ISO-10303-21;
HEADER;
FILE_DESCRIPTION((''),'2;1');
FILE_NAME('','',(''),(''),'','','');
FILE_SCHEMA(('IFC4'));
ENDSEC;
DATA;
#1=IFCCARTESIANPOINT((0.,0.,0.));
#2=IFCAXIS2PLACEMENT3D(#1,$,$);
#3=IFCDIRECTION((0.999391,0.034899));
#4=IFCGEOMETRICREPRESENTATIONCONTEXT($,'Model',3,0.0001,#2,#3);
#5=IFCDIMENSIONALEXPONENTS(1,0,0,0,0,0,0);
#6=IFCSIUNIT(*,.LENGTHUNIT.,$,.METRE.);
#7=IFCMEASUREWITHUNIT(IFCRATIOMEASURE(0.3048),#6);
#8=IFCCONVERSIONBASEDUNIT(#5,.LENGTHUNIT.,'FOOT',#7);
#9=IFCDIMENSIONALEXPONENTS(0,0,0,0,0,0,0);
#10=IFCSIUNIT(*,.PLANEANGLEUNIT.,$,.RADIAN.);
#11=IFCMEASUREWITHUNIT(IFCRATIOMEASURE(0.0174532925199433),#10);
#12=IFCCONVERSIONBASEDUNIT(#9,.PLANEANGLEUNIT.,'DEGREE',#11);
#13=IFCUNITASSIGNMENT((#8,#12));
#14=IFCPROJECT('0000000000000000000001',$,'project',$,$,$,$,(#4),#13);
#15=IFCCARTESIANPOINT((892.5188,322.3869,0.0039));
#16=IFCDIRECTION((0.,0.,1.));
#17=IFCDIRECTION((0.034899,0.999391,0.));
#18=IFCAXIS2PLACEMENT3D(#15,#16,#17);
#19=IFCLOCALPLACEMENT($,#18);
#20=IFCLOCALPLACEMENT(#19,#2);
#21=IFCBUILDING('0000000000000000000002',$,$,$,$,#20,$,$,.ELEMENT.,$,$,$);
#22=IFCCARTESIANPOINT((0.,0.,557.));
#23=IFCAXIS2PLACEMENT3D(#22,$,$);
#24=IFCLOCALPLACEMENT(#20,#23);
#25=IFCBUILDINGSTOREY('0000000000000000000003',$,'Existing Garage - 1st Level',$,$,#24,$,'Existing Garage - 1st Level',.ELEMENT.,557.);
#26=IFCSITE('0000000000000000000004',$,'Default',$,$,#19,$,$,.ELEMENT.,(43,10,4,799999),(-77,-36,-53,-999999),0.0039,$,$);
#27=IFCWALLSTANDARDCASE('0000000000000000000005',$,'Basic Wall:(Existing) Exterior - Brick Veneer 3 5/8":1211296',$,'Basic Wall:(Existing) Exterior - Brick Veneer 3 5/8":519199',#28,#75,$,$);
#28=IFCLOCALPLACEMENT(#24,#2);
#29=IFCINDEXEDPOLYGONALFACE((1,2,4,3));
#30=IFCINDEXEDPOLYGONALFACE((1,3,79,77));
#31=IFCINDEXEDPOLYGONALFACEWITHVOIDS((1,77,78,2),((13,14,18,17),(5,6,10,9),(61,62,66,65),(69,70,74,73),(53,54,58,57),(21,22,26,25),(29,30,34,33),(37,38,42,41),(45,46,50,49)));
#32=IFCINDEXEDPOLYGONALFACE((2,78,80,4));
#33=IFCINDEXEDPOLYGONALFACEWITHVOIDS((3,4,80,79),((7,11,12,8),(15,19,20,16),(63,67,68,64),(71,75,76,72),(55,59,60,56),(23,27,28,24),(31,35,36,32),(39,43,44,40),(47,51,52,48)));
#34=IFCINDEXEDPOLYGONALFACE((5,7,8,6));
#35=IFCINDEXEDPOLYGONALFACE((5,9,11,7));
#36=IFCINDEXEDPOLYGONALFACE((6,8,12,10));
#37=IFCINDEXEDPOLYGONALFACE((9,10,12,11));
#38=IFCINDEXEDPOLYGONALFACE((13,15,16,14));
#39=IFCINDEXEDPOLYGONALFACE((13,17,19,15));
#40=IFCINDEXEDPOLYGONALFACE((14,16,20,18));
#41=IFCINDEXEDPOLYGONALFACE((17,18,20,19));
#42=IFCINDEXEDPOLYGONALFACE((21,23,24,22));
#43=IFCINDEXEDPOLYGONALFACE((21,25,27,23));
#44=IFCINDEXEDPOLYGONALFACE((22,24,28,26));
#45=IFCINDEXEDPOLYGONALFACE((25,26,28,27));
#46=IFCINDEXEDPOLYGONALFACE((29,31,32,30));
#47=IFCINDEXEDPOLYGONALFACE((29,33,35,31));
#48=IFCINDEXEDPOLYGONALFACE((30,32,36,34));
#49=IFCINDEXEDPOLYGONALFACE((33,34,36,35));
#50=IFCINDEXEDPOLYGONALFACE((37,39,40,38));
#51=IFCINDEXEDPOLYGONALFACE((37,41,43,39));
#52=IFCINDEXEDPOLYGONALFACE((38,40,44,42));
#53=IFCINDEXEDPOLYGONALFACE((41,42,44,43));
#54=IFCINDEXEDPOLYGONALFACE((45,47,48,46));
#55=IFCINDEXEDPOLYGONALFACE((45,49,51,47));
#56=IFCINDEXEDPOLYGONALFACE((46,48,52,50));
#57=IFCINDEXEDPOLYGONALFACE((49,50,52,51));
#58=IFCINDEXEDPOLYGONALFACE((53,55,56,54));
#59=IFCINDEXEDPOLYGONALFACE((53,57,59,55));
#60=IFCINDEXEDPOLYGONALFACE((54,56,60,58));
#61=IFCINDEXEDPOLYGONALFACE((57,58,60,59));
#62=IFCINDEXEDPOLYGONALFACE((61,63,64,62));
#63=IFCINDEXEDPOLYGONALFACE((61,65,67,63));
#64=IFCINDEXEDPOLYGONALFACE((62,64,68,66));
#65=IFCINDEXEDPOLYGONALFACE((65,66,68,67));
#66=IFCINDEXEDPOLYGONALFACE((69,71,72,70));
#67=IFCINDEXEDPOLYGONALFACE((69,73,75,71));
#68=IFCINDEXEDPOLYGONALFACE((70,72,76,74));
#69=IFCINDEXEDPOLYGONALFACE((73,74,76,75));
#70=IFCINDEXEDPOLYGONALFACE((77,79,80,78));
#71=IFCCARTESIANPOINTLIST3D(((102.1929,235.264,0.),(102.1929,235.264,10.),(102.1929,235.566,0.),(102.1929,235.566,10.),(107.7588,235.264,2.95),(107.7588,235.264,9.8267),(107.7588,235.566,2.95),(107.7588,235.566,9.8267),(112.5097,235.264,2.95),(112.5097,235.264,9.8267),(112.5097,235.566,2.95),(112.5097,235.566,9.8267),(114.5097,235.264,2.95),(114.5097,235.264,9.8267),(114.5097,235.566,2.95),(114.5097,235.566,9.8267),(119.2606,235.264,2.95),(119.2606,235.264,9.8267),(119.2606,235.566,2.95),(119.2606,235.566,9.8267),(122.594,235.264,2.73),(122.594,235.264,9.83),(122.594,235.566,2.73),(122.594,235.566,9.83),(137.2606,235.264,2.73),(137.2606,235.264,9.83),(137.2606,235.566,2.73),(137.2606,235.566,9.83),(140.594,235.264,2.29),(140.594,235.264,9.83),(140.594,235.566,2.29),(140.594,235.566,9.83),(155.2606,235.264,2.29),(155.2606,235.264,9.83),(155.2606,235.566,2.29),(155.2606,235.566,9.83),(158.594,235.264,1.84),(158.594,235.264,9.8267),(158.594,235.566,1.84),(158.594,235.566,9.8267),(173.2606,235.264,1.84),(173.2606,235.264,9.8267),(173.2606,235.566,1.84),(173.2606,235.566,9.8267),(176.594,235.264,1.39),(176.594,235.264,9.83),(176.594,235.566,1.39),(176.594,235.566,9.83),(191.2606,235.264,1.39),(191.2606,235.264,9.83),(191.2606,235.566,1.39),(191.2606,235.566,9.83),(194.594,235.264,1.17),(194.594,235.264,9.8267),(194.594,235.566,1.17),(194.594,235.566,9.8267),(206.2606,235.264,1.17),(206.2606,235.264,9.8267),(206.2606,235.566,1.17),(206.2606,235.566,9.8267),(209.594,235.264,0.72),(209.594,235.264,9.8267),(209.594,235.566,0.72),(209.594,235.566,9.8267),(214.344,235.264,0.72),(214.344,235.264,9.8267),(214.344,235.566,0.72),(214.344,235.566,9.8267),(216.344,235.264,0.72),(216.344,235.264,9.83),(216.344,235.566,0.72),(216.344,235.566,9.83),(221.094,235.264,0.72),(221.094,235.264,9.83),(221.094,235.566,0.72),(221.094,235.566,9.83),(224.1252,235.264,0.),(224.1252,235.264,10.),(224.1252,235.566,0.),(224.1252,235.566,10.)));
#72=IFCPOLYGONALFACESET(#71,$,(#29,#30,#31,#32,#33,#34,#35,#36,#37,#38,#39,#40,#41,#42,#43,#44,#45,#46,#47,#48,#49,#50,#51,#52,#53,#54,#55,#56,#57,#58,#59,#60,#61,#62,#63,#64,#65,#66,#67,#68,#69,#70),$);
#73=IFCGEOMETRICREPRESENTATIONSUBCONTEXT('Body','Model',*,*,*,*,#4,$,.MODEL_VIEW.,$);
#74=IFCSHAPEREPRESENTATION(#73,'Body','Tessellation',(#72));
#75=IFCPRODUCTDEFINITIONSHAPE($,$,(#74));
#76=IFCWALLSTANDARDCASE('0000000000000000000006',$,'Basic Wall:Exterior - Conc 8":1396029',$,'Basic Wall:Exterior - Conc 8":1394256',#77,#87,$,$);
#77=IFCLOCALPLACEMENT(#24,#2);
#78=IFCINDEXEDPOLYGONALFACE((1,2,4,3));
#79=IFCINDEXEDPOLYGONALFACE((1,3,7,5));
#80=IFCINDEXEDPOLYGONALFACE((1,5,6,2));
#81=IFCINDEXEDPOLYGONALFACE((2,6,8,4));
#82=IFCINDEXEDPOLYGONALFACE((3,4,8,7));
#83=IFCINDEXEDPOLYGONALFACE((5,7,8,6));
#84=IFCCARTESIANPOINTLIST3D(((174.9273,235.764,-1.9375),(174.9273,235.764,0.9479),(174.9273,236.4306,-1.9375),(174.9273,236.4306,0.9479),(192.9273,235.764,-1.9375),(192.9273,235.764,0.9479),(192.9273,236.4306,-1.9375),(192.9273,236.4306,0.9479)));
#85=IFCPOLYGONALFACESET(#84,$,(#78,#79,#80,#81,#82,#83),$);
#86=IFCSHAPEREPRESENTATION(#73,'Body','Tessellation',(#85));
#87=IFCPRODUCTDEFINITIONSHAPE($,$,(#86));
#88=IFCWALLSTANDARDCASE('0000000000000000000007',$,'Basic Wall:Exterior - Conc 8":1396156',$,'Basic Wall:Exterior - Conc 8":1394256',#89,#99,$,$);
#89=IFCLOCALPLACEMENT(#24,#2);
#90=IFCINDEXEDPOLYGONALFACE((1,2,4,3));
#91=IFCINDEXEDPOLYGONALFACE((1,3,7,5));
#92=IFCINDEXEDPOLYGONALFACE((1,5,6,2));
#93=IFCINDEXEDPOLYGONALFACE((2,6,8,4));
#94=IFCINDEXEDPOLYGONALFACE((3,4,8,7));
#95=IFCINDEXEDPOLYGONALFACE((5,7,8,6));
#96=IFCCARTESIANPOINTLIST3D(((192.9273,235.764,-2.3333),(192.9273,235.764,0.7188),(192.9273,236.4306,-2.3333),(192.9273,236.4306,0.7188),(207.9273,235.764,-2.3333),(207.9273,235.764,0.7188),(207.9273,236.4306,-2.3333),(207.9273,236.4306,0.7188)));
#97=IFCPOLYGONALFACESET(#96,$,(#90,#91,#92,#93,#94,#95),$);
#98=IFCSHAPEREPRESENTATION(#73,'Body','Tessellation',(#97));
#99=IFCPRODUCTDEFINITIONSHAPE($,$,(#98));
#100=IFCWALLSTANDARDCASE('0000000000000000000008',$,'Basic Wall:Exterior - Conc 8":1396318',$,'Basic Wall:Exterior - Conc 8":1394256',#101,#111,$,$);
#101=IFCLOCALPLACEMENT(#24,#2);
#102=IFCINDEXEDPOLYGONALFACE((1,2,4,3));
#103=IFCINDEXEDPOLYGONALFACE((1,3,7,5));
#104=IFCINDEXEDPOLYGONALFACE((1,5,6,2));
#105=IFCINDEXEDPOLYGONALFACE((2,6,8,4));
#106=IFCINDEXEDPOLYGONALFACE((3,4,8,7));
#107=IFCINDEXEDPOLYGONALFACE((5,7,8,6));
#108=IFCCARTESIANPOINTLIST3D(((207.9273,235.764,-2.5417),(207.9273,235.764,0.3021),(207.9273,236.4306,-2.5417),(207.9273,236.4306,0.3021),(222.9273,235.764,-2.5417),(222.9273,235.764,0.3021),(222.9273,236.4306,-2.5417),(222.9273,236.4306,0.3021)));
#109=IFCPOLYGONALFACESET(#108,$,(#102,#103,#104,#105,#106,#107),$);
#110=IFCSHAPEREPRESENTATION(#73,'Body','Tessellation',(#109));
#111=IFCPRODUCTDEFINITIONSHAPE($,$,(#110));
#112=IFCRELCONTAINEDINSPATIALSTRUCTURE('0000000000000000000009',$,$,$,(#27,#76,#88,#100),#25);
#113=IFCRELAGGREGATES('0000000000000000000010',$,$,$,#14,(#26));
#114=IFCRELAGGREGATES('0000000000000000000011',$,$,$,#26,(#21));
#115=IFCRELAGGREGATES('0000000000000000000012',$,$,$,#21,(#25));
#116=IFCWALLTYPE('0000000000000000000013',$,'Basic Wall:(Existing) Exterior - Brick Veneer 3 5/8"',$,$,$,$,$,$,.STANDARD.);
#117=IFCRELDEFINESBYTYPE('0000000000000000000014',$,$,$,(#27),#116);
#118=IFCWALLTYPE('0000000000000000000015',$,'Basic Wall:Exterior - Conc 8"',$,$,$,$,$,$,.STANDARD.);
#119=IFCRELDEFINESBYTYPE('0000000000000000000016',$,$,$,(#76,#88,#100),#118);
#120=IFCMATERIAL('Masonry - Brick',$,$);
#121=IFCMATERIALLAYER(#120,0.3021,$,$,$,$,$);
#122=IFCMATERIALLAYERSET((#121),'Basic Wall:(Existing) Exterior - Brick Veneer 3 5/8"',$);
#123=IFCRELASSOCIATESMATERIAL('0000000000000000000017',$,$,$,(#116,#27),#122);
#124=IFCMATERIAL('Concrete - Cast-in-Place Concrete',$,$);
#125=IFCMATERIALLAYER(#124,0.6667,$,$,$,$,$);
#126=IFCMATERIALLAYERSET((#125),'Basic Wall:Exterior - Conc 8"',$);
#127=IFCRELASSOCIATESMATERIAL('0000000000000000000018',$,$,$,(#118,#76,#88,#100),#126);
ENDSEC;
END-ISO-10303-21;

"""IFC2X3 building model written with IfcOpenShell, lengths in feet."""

from ifc_helpers import new_model, entity, si_unit, converted_unit, direction, frame, frame_2d, origin, origin_2d_with_axis, place, context, subcontext, project, spatial, rectangle, extrude, material, layer, layer_set, layer_usage, type_object, element, save


model = new_model("IFC2X3")

# Units and contexts
model_context = context("Model", 3, precision=0.0001, world=origin(), true_north=direction((0.999391, 0.034899)))
body_context = subcontext(model_context, "Body", "Model", "MODEL_VIEW")
ifc_project = project(units=[converted_unit("LENGTHUNIT", "FOOT", entity("IfcRatioMeasure", 0.3048), si_unit("LENGTHUNIT", "METRE"), dimensions=[1, 0, 0, 0, 0, 0, 0]), converted_unit("PLANEANGLEUNIT", "DEGREE", entity("IfcRatioMeasure", 0.0174532925199433), si_unit("PLANEANGLEUNIT", "RADIAN"), dimensions=[0, 0, 0, 0, 0, 0, 0])], contexts=[model_context])

# Site, building, storey
site_placement = place(None, frame((892.5188, 322.3869, 0.0039), z_axis=(0.0, 0.0, 1.0), x_axis=(0.034899, 0.999391, 0.0)))
site = spatial("IfcSite", under=ifc_project, at=site_placement, Name="Default", CompositionType="ELEMENT", RefLatitude=(43, 10, 4, 799999), RefLongitude=(-77, -36, -53, -999999), RefElevation=0.0039)
building_placement = place(site_placement, origin())
building = spatial("IfcBuilding", under=site, at=building_placement, CompositionType="ELEMENT")
storey_placement = place(building_placement, frame((0.0, 0.0, 557.0)))
storey = spatial("IfcBuildingStorey", under=building, at=storey_placement, Name="Existing Garage - 1st Level", LongName="Existing Garage - 1st Level", CompositionType="ELEMENT", Elevation=557.0)

# Shared definitions
ifc_material_1 = material(Name="Concrete - Cast-in-Place Concrete")

# Wall, openings
ifc_material_2 = material(Name="Masonry - Brick")
ifc_layer_1 = layer(ifc_material_2, 0.3021)
ifc_layer_set_1 = layer_set([ifc_layer_1], Name="Basic Wall:(Existing) Exterior - Brick Veneer 3 5/8\"")
ifc_layer_usage_1 = layer_usage(ifc_layer_set_1, "AXIS2", "NEGATIVE", 0.151)
wall_type_1 = type_object("IfcWallType", Name="Basic Wall:(Existing) Exterior - Brick Veneer 3 5/8\"", PredefinedType="STANDARD", material=ifc_layer_set_1)
wall_1_placement = place(storey_placement, frame((224.1252, 235.415, 0.0), z_axis=(0.0, 0.0, 1.0), x_axis=(-1.0, 0.0, 0.0)))
wall_1 = element("IfcWallStandardCase", 1, at=wall_1_placement, inside=storey, type_object=wall_type_1, material=ifc_layer_usage_1, Name="Basic Wall:(Existing) Exterior - Brick Veneer 3 5/8\":1211296", ObjectType="Basic Wall:(Existing) Exterior - Brick Veneer 3 5/8\":519199", context=body_context, shape_type="SweptSolid", body=[
    extrude(rectangle(XDim=121.9323, YDim=0.3021, at=frame_2d((60.9661, 0.0), x_axis=(-1.0, 0.0))), origin(), (0.0, 0.0, 1.0), 10.0),
])
opening_1_placement = place(wall_1_placement, origin())
element("IfcOpeningElement", 2, at=opening_1_placement, cuts=wall_1, ObjectType="Opening", context=body_context, shape_type="SweptSolid", body=[
    extrude(rectangle(XDim=6.8767, YDim=4.7509, at=frame_2d((0.0, 0.0), x_axis=(1.0, 0.0))), frame((113.991, 0.151, 6.3883), z_axis=(0.0, -1.0, 0.0), x_axis=(0.0, 0.0, 1.0)), (0.0, 0.0, 1.0), 0.3021),
])
opening_2_placement = place(wall_1_placement, origin())
element("IfcOpeningElement", 3, at=opening_2_placement, cuts=wall_1, ObjectType="Opening", context=body_context, shape_type="SweptSolid", body=[
    extrude(rectangle(XDim=6.8767, YDim=4.7509, at=frame_2d((0.0, 0.0), x_axis=(1.0, 0.0))), frame((107.2401, 0.151, 6.3883), z_axis=(0.0, -1.0, 0.0), x_axis=(0.0, 0.0, 1.0)), (0.0, 0.0, 1.0), 0.3021),
])
opening_3_placement = place(wall_1_placement, origin())
element("IfcOpeningElement", 4, at=opening_3_placement, cuts=wall_1, ObjectType="Opening", context=body_context, shape_type="SweptSolid", body=[
    extrude(rectangle(XDim=7.1, YDim=14.6667, at=frame_2d((0.0, 0.0), x_axis=(1.0, 0.0))), frame((94.1979, 0.151, 6.28), z_axis=(0.0, -1.0, 0.0), x_axis=(0.0, 0.0, 1.0)), (0.0, 0.0, 1.0), 0.3021),
])
opening_4_placement = place(wall_1_placement, origin())
element("IfcOpeningElement", 5, at=opening_4_placement, cuts=wall_1, ObjectType="Opening", context=body_context, shape_type="SweptSolid", body=[
    extrude(rectangle(XDim=7.54, YDim=14.6667, at=frame_2d((0.0, 0.0), x_axis=(1.0, 0.0))), frame((76.1979, 0.151, 6.06), z_axis=(0.0, -1.0, 0.0), x_axis=(0.0, 0.0, 1.0)), (0.0, 0.0, 1.0), 0.3021),
])
opening_5_placement = place(wall_1_placement, origin())
element("IfcOpeningElement", 6, at=opening_5_placement, cuts=wall_1, ObjectType="Opening", context=body_context, shape_type="SweptSolid", body=[
    extrude(rectangle(XDim=7.9867, YDim=14.6667, at=frame_2d((0.0, 0.0), x_axis=(1.0, 0.0))), frame((58.1979, 0.151, 5.8333), z_axis=(0.0, -1.0, 0.0), x_axis=(0.0, 0.0, 1.0)), (0.0, 0.0, 1.0), 0.3021),
])
opening_6_placement = place(wall_1_placement, origin())
element("IfcOpeningElement", 7, at=opening_6_placement, cuts=wall_1, ObjectType="Opening", context=body_context, shape_type="SweptSolid", body=[
    extrude(rectangle(XDim=8.44, YDim=14.6667, at=origin_2d_with_axis()), frame((40.1979, 0.151, 5.61), z_axis=(0.0, -1.0, 0.0), x_axis=(0.0, 0.0, 1.0)), (0.0, 0.0, 1.0), 0.3021),
])
opening_7_placement = place(wall_1_placement, origin())
element("IfcOpeningElement", 8, at=opening_7_placement, cuts=wall_1, ObjectType="Opening", context=body_context, shape_type="SweptSolid", body=[
    extrude(rectangle(XDim=8.6567, YDim=11.6667, at=frame_2d((0.0, 0.0), x_axis=(1.0, 0.0))), frame((23.6979, 0.151, 5.4983), z_axis=(0.0, -1.0, 0.0), x_axis=(0.0, 0.0, 1.0)), (0.0, 0.0, 1.0), 0.3021),
])
opening_8_placement = place(wall_1_placement, origin())
element("IfcOpeningElement", 9, at=opening_8_placement, cuts=wall_1, ObjectType="Opening", context=body_context, shape_type="SweptSolid", body=[
    extrude(rectangle(XDim=9.1067, YDim=4.75, at=frame_2d((0.0, 0.0), x_axis=(1.0, 0.0))), frame((12.1563, 0.151, 5.2733), z_axis=(0.0, -1.0, 0.0), x_axis=(0.0, 0.0, 1.0)), (0.0, 0.0, 1.0), 0.3021),
])
opening_9_placement = place(wall_1_placement, origin())
element("IfcOpeningElement", 10, at=opening_9_placement, cuts=wall_1, ObjectType="Opening", context=body_context, shape_type="SweptSolid", body=[
    extrude(rectangle(XDim=9.11, YDim=4.75, at=frame_2d((0.0, 0.0), x_axis=(1.0, 0.0))), frame((5.4063, 0.151, 5.275), z_axis=(0.0, -1.0, 0.0), x_axis=(0.0, 0.0, 1.0)), (0.0, 0.0, 1.0), 0.3021),
])

# Walls
ifc_layer_2 = layer(ifc_material_1, 0.6667)
ifc_layer_set_2 = layer_set([ifc_layer_2], Name="Basic Wall:Exterior - Conc 8\"")
ifc_layer_usage_2 = layer_usage(ifc_layer_set_2, "AXIS2", "NEGATIVE", 0.3333)
wall_type_2 = type_object("IfcWallType", Name="Basic Wall:Exterior - Conc 8\"", PredefinedType="STANDARD", material=ifc_layer_set_2)
wall_2_placement = place(storey_placement, frame((192.9273, 236.0973, -1.9375), z_axis=(0.0, 0.0, 1.0), x_axis=(-1.0, 0.0, 0.0)))
element("IfcWallStandardCase", 11, at=wall_2_placement, inside=storey, type_object=wall_type_2, material=ifc_layer_usage_2, Name="Basic Wall:Exterior - Conc 8\":1396029", ObjectType="Basic Wall:Exterior - Conc 8\":1394256", context=body_context, shape_type="SweptSolid", body=[
    extrude(rectangle(XDim=18.0, YDim=0.6667, at=frame_2d((9.0, 0.0), x_axis=(-1.0, 0.0))), origin(), (0.0, 0.0, 1.0), 2.8854),
])
ifc_layer_usage_3 = layer_usage(ifc_layer_set_2, "AXIS2", "POSITIVE", -0.3333)
wall_3_placement = place(storey_placement, frame((192.9273, 236.0973, -2.3333)))
element("IfcWallStandardCase", 12, at=wall_3_placement, inside=storey, type_object=wall_type_2, material=ifc_layer_usage_3, Name="Basic Wall:Exterior - Conc 8\":1396156", ObjectType="Basic Wall:Exterior - Conc 8\":1394256", context=body_context, shape_type="SweptSolid", body=[
    extrude(rectangle(XDim=15.0, YDim=0.6667, at=frame_2d((7.5, 0.0), x_axis=(-1.0, 0.0))), origin(), (0.0, 0.0, 1.0), 3.0521),
])
ifc_layer_usage_4 = layer_usage(ifc_layer_set_2, "AXIS2", "NEGATIVE", 0.3333)
wall_4_placement = place(storey_placement, frame((222.9273, 236.0973, -2.5417), z_axis=(0.0, 0.0, 1.0), x_axis=(-1.0, 0.0, 0.0)))
element("IfcWallStandardCase", 13, at=wall_4_placement, inside=storey, type_object=wall_type_2, material=ifc_layer_usage_4, Name="Basic Wall:Exterior - Conc 8\":1396318", ObjectType="Basic Wall:Exterior - Conc 8\":1394256", context=body_context, shape_type="SweptSolid", body=[
    extrude(rectangle(XDim=15.0, YDim=0.6667, at=frame_2d((7.5, 0.0), x_axis=(-1.0, 0.0))), origin(), (0.0, 0.0, 1.0), 2.8438),
])

save(model, "model.ifc")
